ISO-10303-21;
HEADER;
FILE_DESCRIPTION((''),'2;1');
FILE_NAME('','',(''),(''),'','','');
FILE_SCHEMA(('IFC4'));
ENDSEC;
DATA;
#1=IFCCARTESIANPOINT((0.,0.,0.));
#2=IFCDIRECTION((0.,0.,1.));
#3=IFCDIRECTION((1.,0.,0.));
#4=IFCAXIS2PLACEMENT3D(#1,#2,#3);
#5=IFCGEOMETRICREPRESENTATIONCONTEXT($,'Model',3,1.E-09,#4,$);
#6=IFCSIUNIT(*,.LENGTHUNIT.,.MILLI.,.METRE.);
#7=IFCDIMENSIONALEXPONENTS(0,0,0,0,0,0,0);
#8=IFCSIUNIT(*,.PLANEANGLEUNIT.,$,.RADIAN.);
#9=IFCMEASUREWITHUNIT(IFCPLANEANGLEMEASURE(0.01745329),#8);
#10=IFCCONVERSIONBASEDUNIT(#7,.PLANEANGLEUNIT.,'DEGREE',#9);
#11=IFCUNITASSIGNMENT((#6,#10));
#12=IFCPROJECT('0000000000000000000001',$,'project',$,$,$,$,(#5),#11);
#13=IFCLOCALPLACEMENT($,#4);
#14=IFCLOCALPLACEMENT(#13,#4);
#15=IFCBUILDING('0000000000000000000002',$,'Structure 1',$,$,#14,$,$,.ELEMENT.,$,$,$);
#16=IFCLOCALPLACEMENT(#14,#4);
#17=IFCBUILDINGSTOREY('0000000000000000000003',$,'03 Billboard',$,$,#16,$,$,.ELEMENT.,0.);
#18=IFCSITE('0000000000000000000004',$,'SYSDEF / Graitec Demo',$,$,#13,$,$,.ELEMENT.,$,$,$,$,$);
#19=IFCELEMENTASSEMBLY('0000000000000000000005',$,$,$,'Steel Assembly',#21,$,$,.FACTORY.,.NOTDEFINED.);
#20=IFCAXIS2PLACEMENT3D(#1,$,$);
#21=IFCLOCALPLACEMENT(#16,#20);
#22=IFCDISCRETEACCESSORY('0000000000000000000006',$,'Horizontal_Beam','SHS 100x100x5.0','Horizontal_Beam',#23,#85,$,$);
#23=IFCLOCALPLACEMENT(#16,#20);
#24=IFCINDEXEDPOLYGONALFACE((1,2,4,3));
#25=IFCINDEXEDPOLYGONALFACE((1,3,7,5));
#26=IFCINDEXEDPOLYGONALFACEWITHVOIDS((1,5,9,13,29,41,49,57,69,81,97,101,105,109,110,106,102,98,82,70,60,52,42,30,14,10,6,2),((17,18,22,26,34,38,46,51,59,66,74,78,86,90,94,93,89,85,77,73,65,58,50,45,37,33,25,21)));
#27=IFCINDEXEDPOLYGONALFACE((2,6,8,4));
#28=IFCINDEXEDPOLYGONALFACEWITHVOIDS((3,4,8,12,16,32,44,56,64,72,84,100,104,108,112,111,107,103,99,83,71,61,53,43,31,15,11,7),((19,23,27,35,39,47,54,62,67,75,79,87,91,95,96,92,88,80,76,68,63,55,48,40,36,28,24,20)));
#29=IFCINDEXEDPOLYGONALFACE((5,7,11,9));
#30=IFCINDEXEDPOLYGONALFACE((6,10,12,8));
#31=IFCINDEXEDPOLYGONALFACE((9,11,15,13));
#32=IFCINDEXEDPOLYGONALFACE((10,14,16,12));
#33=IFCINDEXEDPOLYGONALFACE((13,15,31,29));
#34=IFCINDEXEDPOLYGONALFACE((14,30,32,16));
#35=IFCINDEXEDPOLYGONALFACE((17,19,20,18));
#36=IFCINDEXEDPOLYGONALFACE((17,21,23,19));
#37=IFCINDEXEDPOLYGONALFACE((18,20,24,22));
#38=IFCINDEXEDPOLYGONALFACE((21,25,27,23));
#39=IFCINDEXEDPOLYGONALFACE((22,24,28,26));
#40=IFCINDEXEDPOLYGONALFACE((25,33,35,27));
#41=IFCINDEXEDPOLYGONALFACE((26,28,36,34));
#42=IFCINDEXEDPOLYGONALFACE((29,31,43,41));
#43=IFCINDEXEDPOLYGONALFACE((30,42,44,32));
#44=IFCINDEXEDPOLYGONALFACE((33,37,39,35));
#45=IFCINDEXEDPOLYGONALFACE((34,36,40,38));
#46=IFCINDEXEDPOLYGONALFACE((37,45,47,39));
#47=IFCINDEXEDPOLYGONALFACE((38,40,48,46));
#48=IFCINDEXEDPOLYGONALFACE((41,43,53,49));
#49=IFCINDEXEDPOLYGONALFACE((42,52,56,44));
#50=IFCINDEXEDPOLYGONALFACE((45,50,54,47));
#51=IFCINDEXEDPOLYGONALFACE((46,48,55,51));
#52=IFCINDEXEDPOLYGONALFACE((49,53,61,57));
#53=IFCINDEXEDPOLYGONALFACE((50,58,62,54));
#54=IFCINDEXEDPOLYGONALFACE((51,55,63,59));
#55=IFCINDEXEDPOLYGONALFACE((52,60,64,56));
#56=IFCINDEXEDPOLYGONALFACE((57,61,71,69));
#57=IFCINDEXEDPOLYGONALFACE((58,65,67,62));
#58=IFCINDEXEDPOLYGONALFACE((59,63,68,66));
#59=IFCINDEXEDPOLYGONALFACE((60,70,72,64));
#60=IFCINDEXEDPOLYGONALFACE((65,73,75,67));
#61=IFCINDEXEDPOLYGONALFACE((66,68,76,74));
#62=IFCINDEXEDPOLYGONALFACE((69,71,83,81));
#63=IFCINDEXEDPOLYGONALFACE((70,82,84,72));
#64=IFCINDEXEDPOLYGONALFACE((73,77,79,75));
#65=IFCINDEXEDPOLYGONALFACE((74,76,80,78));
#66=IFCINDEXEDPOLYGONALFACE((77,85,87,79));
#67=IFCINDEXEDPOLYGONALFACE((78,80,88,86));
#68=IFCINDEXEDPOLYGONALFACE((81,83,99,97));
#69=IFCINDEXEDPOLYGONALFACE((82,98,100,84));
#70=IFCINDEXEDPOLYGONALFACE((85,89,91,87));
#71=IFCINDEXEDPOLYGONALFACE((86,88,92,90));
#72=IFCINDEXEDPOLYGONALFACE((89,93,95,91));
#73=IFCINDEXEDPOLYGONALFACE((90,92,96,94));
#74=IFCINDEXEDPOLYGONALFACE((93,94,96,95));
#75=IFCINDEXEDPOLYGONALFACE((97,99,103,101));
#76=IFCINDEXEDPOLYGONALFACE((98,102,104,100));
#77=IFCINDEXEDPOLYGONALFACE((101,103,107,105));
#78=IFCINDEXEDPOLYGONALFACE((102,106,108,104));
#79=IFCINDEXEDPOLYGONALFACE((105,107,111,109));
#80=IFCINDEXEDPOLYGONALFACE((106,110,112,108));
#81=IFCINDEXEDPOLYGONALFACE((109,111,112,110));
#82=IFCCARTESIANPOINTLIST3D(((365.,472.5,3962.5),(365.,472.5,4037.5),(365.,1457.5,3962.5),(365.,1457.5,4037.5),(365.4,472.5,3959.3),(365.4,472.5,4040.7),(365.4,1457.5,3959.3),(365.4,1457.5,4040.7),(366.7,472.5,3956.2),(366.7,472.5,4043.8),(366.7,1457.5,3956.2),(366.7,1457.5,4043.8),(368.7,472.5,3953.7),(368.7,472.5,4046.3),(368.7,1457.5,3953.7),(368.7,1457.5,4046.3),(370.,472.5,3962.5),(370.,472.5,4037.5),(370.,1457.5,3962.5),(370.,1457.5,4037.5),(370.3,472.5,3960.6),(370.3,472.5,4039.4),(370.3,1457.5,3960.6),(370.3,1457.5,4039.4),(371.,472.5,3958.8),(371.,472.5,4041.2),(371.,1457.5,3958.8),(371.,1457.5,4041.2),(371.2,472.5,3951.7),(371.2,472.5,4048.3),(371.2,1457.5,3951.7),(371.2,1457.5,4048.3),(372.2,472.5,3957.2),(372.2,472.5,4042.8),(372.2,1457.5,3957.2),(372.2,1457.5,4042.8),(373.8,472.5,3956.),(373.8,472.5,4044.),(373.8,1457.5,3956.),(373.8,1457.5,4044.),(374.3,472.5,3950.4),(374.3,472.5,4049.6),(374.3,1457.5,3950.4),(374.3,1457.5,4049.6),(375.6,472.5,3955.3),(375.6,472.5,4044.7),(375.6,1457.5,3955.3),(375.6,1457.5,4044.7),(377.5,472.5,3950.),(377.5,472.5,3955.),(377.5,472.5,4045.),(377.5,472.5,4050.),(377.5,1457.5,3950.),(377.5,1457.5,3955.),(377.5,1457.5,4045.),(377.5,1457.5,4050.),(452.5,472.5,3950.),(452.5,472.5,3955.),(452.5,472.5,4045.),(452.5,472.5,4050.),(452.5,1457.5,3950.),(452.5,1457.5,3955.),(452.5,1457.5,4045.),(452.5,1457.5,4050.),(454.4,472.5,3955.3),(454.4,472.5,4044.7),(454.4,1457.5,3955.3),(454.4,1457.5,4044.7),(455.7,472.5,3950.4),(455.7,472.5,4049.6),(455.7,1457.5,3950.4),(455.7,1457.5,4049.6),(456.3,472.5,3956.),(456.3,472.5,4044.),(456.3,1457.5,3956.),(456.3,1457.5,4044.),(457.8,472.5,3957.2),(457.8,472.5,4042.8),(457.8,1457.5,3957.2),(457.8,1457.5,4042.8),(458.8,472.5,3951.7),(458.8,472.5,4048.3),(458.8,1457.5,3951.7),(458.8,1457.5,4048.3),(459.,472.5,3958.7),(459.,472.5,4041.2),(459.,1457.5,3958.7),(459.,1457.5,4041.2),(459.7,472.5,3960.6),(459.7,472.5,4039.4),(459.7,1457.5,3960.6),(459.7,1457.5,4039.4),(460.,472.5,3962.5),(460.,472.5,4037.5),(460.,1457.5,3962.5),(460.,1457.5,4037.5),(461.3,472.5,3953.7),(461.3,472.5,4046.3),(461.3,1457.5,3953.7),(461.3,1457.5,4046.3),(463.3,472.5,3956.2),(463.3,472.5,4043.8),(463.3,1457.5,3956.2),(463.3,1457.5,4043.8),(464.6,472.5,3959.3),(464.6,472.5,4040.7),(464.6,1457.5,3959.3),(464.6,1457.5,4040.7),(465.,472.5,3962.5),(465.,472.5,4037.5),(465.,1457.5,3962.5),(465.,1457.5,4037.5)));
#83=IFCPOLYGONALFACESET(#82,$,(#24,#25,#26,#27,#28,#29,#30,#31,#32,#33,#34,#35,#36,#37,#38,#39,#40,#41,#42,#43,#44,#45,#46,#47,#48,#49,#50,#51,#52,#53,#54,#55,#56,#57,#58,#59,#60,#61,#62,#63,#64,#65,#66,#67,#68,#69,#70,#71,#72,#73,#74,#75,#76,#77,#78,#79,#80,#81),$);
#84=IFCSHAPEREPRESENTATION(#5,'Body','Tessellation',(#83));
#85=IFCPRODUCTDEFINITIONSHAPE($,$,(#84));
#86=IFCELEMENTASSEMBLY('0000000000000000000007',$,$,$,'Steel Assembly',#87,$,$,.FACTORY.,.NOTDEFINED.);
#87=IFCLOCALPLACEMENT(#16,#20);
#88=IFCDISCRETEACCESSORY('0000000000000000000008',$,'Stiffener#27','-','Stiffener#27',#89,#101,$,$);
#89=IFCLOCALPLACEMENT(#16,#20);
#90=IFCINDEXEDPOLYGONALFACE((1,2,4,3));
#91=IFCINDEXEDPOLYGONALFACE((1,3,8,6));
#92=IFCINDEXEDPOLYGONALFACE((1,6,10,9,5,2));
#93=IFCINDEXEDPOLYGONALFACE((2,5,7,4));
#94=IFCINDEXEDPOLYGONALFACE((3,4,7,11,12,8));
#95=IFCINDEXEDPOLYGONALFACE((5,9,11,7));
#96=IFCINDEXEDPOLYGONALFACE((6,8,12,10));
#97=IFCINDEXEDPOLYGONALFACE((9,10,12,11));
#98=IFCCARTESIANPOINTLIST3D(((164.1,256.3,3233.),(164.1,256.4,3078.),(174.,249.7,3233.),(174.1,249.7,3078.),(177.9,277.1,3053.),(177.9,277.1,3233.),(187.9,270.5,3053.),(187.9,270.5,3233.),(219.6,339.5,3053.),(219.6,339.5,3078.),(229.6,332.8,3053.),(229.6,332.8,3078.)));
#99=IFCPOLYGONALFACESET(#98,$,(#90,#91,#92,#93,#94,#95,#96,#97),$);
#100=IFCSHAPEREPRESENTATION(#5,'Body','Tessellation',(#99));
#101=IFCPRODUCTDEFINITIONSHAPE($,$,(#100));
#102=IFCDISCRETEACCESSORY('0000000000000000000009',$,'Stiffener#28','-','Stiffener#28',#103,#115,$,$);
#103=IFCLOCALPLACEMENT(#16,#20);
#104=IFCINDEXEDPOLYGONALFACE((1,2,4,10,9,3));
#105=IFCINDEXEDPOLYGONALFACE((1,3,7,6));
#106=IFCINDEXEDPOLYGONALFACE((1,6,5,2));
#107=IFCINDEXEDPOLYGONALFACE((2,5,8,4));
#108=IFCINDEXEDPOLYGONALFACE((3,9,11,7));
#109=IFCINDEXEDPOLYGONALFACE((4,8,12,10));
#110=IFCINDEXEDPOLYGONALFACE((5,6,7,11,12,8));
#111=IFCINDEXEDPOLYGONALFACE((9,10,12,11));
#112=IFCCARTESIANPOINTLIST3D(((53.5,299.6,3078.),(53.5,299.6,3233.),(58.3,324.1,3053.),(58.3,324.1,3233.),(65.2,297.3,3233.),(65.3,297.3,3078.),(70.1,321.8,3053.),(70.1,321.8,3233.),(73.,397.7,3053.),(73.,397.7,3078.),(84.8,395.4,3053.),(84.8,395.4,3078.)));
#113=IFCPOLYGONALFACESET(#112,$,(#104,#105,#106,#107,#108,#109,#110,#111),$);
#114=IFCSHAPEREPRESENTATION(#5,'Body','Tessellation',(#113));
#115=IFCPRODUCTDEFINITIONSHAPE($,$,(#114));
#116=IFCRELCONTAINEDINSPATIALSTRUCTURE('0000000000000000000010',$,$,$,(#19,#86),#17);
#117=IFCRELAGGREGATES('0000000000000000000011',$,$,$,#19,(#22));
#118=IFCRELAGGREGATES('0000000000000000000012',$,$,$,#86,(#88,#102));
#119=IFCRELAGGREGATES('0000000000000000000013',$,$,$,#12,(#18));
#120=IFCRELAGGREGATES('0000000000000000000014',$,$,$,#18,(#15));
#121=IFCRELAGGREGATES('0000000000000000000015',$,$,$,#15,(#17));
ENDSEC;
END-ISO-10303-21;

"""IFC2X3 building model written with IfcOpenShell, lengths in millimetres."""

from ifc_helpers import new_model, entity, si_unit, converted_unit, frame, origin, origin_with_axes, origin_2d, place, context, project, spatial, polyline, hollow_rectangle, outline, extrude, clip, halfspace, element, aggregate, save


model = new_model("IFC2X3")

# Units and contexts
model_context = context("Model", 3, precision=1e-09, world=origin_with_axes())
ifc_project = project(units=[si_unit("LENGTHUNIT", "METRE", prefix="MILLI"), converted_unit("PLANEANGLEUNIT", "DEGREE", entity("IfcPlaneAngleMeasure", 0.01745329), si_unit("PLANEANGLEUNIT", "RADIAN"), dimensions=[0, 0, 0, 0, 0, 0, 0])], contexts=[model_context])

# Site, building, storey
site_placement = place(None, origin_with_axes())
site = spatial("IfcSite", under=ifc_project, at=site_placement, Name="SYSDEF / Graitec Demo", CompositionType="ELEMENT")
building_placement = place(site_placement, origin_with_axes())
building = spatial("IfcBuilding", under=site, at=building_placement, Name="Structure 1", CompositionType="ELEMENT")
storey_placement = place(building_placement, origin_with_axes())
storey = spatial("IfcBuildingStorey", under=building, at=storey_placement, Name="03 Billboard", CompositionType="ELEMENT", Elevation=0.0)

# Element assembly, discrete accessory
assembly_1_placement = place(None, frame((-415.0, 391.8, 4000.0), z_axis=(0.0, -1.0, 0.0), x_axis=(1.0, 0.0, 0.0)))
assembly_1 = element("IfcElementAssembly", 1, at=assembly_1_placement, inside=storey, ObjectType="Steel Assembly", AssemblyPlace="FACTORY", PredefinedType="NOTDEFINED")
discrete_accessory_1_placement = place(assembly_1_placement, frame((830.0, 0.0, 0.0), z_axis=(0.0, 0.0, 1.0), x_axis=(1.0, 0.0, 0.0)))
discrete_accessory_1 = element("IfcDiscreteAccessory", 2, at=discrete_accessory_1_placement, Name="Horizontal_Beam", Description="SHS 100x100x5.0", ObjectType="Horizontal_Beam", context=model_context, shape_type="Clipping", body=[
    clip(clip(extrude(hollow_rectangle(XDim=100.0, YDim=100.0, WallThickness=5.0, InnerFilletRadius=7.5, OuterFilletRadius=12.5, at=origin_2d()), origin(), (0.0, 0.0, -1.0), 1141.4), halfspace(frame((-415.0, -4000.0, -1065.7), z_axis=(0.0, 0.0, 1.0), x_axis=(1.0, 0.0, 0.0)), True)), halfspace(frame((-415.0, -4000.0, -80.7), z_axis=(0.0, 0.0, -1.0), x_axis=(-1.0, 0.0, 0.0)), True)),
])
aggregate(assembly_1, [discrete_accessory_1])

# Element assembly, discrete accessories, openings
assembly_2_placement = place(None, frame((-4406.3, 0.0, 3558.0), z_axis=(-1.0, 0.0, 0.0), x_axis=(0.0, -1.0, 0.0)))
assembly_2 = element("IfcElementAssembly", 3, at=assembly_2_placement, inside=storey, ObjectType="Steel Assembly", AssemblyPlace="FACTORY", PredefinedType="NOTDEFINED")
discrete_accessory_2_placement = place(assembly_2_placement, frame((-249.7, -505.0, -4580.4), z_axis=(-0.55557, 0.0, 0.83147), x_axis=(0.0, 1.0, 0.0)))
discrete_accessory_2 = element("IfcDiscreteAccessory", 4, at=discrete_accessory_2_placement, Name="Stiffener#27", Description="-", ObjectType="Stiffener#27", context=model_context, shape_type="SweptSolid", body=[
    extrude(outline(polyline([(0.0, 0.0), (180.0, 0.0), (180.0, 100.0), (0.0, 100.0), (0.0, 0.0)])), origin_with_axes(), (0.0, 0.0, 1.0), 12.0),
])
opening_1_placement = place(discrete_accessory_2_placement, frame((0.0, 0.0, 0.0), z_axis=(0.0, 0.0, 1.0), x_axis=(1.0, 0.0, 0.0)))
element("IfcOpeningElement", 5, at=opening_1_placement, cuts=discrete_accessory_2, ObjectType="Opening", context=model_context, shape_type="SweptSolid", body=[
    extrude(outline(polyline([(180.0, 100.0), (25.0, 100.0), (180.0, 25.0), (180.0, 100.0)])), origin(), (0.0, 0.0, 1.0), 12.0),
])
opening_2_placement = place(discrete_accessory_2_placement, frame((0.0, 0.0, 0.0), z_axis=(0.0, 0.0, 1.0), x_axis=(1.0, 0.0, 0.0)))
element("IfcOpeningElement", 6, at=opening_2_placement, cuts=discrete_accessory_2, ObjectType="Opening", context=model_context, shape_type="SweptSolid", body=[
    extrude(outline(polyline([(0.0, 0.0), (25.0, 0.0), (0.0, 25.0), (0.0, 0.0)])), origin(), (0.0, 0.0, 1.0), 12.0),
])
discrete_accessory_3_placement = place(assembly_2_placement, frame((-297.3, -505.0, -4471.6), z_axis=(-0.19509, 0.0, 0.980785), x_axis=(0.0, 1.0, 0.0)))
discrete_accessory_3 = element("IfcDiscreteAccessory", 7, at=discrete_accessory_3_placement, Name="Stiffener#28", Description="-", ObjectType="Stiffener#28", context=model_context, shape_type="SweptSolid", body=[
    extrude(outline(polyline([(0.0, 0.0), (180.0, 0.0), (180.0, 100.0), (0.0, 100.0), (0.0, 0.0)])), origin_with_axes(), (0.0, 0.0, 1.0), 12.0),
])
opening_3_placement = place(discrete_accessory_3_placement, frame((0.0, 0.0, 0.0), z_axis=(0.0, 0.0, 1.0), x_axis=(1.0, 0.0, 0.0)))
element("IfcOpeningElement", 8, at=opening_3_placement, cuts=discrete_accessory_3, ObjectType="Opening", context=model_context, shape_type="SweptSolid", body=[
    extrude(outline(polyline([(180.0, 100.0), (25.0, 100.0), (180.0, 25.0), (180.0, 100.0)])), origin(), (0.0, 0.0, 1.0), 12.0),
])
opening_4_placement = place(discrete_accessory_3_placement, frame((0.0, 0.0, 0.0), z_axis=(0.0, 0.0, 1.0), x_axis=(1.0, 0.0, 0.0)))
element("IfcOpeningElement", 9, at=opening_4_placement, cuts=discrete_accessory_3, ObjectType="Opening", context=model_context, shape_type="SweptSolid", body=[
    extrude(outline(polyline([(0.0, 0.0), (25.0, 0.0), (0.0, 25.0), (0.0, 0.0)])), origin(), (0.0, 0.0, 1.0), 12.0),
])
aggregate(assembly_2, [discrete_accessory_2, discrete_accessory_3])

save(model, "model.ifc")
